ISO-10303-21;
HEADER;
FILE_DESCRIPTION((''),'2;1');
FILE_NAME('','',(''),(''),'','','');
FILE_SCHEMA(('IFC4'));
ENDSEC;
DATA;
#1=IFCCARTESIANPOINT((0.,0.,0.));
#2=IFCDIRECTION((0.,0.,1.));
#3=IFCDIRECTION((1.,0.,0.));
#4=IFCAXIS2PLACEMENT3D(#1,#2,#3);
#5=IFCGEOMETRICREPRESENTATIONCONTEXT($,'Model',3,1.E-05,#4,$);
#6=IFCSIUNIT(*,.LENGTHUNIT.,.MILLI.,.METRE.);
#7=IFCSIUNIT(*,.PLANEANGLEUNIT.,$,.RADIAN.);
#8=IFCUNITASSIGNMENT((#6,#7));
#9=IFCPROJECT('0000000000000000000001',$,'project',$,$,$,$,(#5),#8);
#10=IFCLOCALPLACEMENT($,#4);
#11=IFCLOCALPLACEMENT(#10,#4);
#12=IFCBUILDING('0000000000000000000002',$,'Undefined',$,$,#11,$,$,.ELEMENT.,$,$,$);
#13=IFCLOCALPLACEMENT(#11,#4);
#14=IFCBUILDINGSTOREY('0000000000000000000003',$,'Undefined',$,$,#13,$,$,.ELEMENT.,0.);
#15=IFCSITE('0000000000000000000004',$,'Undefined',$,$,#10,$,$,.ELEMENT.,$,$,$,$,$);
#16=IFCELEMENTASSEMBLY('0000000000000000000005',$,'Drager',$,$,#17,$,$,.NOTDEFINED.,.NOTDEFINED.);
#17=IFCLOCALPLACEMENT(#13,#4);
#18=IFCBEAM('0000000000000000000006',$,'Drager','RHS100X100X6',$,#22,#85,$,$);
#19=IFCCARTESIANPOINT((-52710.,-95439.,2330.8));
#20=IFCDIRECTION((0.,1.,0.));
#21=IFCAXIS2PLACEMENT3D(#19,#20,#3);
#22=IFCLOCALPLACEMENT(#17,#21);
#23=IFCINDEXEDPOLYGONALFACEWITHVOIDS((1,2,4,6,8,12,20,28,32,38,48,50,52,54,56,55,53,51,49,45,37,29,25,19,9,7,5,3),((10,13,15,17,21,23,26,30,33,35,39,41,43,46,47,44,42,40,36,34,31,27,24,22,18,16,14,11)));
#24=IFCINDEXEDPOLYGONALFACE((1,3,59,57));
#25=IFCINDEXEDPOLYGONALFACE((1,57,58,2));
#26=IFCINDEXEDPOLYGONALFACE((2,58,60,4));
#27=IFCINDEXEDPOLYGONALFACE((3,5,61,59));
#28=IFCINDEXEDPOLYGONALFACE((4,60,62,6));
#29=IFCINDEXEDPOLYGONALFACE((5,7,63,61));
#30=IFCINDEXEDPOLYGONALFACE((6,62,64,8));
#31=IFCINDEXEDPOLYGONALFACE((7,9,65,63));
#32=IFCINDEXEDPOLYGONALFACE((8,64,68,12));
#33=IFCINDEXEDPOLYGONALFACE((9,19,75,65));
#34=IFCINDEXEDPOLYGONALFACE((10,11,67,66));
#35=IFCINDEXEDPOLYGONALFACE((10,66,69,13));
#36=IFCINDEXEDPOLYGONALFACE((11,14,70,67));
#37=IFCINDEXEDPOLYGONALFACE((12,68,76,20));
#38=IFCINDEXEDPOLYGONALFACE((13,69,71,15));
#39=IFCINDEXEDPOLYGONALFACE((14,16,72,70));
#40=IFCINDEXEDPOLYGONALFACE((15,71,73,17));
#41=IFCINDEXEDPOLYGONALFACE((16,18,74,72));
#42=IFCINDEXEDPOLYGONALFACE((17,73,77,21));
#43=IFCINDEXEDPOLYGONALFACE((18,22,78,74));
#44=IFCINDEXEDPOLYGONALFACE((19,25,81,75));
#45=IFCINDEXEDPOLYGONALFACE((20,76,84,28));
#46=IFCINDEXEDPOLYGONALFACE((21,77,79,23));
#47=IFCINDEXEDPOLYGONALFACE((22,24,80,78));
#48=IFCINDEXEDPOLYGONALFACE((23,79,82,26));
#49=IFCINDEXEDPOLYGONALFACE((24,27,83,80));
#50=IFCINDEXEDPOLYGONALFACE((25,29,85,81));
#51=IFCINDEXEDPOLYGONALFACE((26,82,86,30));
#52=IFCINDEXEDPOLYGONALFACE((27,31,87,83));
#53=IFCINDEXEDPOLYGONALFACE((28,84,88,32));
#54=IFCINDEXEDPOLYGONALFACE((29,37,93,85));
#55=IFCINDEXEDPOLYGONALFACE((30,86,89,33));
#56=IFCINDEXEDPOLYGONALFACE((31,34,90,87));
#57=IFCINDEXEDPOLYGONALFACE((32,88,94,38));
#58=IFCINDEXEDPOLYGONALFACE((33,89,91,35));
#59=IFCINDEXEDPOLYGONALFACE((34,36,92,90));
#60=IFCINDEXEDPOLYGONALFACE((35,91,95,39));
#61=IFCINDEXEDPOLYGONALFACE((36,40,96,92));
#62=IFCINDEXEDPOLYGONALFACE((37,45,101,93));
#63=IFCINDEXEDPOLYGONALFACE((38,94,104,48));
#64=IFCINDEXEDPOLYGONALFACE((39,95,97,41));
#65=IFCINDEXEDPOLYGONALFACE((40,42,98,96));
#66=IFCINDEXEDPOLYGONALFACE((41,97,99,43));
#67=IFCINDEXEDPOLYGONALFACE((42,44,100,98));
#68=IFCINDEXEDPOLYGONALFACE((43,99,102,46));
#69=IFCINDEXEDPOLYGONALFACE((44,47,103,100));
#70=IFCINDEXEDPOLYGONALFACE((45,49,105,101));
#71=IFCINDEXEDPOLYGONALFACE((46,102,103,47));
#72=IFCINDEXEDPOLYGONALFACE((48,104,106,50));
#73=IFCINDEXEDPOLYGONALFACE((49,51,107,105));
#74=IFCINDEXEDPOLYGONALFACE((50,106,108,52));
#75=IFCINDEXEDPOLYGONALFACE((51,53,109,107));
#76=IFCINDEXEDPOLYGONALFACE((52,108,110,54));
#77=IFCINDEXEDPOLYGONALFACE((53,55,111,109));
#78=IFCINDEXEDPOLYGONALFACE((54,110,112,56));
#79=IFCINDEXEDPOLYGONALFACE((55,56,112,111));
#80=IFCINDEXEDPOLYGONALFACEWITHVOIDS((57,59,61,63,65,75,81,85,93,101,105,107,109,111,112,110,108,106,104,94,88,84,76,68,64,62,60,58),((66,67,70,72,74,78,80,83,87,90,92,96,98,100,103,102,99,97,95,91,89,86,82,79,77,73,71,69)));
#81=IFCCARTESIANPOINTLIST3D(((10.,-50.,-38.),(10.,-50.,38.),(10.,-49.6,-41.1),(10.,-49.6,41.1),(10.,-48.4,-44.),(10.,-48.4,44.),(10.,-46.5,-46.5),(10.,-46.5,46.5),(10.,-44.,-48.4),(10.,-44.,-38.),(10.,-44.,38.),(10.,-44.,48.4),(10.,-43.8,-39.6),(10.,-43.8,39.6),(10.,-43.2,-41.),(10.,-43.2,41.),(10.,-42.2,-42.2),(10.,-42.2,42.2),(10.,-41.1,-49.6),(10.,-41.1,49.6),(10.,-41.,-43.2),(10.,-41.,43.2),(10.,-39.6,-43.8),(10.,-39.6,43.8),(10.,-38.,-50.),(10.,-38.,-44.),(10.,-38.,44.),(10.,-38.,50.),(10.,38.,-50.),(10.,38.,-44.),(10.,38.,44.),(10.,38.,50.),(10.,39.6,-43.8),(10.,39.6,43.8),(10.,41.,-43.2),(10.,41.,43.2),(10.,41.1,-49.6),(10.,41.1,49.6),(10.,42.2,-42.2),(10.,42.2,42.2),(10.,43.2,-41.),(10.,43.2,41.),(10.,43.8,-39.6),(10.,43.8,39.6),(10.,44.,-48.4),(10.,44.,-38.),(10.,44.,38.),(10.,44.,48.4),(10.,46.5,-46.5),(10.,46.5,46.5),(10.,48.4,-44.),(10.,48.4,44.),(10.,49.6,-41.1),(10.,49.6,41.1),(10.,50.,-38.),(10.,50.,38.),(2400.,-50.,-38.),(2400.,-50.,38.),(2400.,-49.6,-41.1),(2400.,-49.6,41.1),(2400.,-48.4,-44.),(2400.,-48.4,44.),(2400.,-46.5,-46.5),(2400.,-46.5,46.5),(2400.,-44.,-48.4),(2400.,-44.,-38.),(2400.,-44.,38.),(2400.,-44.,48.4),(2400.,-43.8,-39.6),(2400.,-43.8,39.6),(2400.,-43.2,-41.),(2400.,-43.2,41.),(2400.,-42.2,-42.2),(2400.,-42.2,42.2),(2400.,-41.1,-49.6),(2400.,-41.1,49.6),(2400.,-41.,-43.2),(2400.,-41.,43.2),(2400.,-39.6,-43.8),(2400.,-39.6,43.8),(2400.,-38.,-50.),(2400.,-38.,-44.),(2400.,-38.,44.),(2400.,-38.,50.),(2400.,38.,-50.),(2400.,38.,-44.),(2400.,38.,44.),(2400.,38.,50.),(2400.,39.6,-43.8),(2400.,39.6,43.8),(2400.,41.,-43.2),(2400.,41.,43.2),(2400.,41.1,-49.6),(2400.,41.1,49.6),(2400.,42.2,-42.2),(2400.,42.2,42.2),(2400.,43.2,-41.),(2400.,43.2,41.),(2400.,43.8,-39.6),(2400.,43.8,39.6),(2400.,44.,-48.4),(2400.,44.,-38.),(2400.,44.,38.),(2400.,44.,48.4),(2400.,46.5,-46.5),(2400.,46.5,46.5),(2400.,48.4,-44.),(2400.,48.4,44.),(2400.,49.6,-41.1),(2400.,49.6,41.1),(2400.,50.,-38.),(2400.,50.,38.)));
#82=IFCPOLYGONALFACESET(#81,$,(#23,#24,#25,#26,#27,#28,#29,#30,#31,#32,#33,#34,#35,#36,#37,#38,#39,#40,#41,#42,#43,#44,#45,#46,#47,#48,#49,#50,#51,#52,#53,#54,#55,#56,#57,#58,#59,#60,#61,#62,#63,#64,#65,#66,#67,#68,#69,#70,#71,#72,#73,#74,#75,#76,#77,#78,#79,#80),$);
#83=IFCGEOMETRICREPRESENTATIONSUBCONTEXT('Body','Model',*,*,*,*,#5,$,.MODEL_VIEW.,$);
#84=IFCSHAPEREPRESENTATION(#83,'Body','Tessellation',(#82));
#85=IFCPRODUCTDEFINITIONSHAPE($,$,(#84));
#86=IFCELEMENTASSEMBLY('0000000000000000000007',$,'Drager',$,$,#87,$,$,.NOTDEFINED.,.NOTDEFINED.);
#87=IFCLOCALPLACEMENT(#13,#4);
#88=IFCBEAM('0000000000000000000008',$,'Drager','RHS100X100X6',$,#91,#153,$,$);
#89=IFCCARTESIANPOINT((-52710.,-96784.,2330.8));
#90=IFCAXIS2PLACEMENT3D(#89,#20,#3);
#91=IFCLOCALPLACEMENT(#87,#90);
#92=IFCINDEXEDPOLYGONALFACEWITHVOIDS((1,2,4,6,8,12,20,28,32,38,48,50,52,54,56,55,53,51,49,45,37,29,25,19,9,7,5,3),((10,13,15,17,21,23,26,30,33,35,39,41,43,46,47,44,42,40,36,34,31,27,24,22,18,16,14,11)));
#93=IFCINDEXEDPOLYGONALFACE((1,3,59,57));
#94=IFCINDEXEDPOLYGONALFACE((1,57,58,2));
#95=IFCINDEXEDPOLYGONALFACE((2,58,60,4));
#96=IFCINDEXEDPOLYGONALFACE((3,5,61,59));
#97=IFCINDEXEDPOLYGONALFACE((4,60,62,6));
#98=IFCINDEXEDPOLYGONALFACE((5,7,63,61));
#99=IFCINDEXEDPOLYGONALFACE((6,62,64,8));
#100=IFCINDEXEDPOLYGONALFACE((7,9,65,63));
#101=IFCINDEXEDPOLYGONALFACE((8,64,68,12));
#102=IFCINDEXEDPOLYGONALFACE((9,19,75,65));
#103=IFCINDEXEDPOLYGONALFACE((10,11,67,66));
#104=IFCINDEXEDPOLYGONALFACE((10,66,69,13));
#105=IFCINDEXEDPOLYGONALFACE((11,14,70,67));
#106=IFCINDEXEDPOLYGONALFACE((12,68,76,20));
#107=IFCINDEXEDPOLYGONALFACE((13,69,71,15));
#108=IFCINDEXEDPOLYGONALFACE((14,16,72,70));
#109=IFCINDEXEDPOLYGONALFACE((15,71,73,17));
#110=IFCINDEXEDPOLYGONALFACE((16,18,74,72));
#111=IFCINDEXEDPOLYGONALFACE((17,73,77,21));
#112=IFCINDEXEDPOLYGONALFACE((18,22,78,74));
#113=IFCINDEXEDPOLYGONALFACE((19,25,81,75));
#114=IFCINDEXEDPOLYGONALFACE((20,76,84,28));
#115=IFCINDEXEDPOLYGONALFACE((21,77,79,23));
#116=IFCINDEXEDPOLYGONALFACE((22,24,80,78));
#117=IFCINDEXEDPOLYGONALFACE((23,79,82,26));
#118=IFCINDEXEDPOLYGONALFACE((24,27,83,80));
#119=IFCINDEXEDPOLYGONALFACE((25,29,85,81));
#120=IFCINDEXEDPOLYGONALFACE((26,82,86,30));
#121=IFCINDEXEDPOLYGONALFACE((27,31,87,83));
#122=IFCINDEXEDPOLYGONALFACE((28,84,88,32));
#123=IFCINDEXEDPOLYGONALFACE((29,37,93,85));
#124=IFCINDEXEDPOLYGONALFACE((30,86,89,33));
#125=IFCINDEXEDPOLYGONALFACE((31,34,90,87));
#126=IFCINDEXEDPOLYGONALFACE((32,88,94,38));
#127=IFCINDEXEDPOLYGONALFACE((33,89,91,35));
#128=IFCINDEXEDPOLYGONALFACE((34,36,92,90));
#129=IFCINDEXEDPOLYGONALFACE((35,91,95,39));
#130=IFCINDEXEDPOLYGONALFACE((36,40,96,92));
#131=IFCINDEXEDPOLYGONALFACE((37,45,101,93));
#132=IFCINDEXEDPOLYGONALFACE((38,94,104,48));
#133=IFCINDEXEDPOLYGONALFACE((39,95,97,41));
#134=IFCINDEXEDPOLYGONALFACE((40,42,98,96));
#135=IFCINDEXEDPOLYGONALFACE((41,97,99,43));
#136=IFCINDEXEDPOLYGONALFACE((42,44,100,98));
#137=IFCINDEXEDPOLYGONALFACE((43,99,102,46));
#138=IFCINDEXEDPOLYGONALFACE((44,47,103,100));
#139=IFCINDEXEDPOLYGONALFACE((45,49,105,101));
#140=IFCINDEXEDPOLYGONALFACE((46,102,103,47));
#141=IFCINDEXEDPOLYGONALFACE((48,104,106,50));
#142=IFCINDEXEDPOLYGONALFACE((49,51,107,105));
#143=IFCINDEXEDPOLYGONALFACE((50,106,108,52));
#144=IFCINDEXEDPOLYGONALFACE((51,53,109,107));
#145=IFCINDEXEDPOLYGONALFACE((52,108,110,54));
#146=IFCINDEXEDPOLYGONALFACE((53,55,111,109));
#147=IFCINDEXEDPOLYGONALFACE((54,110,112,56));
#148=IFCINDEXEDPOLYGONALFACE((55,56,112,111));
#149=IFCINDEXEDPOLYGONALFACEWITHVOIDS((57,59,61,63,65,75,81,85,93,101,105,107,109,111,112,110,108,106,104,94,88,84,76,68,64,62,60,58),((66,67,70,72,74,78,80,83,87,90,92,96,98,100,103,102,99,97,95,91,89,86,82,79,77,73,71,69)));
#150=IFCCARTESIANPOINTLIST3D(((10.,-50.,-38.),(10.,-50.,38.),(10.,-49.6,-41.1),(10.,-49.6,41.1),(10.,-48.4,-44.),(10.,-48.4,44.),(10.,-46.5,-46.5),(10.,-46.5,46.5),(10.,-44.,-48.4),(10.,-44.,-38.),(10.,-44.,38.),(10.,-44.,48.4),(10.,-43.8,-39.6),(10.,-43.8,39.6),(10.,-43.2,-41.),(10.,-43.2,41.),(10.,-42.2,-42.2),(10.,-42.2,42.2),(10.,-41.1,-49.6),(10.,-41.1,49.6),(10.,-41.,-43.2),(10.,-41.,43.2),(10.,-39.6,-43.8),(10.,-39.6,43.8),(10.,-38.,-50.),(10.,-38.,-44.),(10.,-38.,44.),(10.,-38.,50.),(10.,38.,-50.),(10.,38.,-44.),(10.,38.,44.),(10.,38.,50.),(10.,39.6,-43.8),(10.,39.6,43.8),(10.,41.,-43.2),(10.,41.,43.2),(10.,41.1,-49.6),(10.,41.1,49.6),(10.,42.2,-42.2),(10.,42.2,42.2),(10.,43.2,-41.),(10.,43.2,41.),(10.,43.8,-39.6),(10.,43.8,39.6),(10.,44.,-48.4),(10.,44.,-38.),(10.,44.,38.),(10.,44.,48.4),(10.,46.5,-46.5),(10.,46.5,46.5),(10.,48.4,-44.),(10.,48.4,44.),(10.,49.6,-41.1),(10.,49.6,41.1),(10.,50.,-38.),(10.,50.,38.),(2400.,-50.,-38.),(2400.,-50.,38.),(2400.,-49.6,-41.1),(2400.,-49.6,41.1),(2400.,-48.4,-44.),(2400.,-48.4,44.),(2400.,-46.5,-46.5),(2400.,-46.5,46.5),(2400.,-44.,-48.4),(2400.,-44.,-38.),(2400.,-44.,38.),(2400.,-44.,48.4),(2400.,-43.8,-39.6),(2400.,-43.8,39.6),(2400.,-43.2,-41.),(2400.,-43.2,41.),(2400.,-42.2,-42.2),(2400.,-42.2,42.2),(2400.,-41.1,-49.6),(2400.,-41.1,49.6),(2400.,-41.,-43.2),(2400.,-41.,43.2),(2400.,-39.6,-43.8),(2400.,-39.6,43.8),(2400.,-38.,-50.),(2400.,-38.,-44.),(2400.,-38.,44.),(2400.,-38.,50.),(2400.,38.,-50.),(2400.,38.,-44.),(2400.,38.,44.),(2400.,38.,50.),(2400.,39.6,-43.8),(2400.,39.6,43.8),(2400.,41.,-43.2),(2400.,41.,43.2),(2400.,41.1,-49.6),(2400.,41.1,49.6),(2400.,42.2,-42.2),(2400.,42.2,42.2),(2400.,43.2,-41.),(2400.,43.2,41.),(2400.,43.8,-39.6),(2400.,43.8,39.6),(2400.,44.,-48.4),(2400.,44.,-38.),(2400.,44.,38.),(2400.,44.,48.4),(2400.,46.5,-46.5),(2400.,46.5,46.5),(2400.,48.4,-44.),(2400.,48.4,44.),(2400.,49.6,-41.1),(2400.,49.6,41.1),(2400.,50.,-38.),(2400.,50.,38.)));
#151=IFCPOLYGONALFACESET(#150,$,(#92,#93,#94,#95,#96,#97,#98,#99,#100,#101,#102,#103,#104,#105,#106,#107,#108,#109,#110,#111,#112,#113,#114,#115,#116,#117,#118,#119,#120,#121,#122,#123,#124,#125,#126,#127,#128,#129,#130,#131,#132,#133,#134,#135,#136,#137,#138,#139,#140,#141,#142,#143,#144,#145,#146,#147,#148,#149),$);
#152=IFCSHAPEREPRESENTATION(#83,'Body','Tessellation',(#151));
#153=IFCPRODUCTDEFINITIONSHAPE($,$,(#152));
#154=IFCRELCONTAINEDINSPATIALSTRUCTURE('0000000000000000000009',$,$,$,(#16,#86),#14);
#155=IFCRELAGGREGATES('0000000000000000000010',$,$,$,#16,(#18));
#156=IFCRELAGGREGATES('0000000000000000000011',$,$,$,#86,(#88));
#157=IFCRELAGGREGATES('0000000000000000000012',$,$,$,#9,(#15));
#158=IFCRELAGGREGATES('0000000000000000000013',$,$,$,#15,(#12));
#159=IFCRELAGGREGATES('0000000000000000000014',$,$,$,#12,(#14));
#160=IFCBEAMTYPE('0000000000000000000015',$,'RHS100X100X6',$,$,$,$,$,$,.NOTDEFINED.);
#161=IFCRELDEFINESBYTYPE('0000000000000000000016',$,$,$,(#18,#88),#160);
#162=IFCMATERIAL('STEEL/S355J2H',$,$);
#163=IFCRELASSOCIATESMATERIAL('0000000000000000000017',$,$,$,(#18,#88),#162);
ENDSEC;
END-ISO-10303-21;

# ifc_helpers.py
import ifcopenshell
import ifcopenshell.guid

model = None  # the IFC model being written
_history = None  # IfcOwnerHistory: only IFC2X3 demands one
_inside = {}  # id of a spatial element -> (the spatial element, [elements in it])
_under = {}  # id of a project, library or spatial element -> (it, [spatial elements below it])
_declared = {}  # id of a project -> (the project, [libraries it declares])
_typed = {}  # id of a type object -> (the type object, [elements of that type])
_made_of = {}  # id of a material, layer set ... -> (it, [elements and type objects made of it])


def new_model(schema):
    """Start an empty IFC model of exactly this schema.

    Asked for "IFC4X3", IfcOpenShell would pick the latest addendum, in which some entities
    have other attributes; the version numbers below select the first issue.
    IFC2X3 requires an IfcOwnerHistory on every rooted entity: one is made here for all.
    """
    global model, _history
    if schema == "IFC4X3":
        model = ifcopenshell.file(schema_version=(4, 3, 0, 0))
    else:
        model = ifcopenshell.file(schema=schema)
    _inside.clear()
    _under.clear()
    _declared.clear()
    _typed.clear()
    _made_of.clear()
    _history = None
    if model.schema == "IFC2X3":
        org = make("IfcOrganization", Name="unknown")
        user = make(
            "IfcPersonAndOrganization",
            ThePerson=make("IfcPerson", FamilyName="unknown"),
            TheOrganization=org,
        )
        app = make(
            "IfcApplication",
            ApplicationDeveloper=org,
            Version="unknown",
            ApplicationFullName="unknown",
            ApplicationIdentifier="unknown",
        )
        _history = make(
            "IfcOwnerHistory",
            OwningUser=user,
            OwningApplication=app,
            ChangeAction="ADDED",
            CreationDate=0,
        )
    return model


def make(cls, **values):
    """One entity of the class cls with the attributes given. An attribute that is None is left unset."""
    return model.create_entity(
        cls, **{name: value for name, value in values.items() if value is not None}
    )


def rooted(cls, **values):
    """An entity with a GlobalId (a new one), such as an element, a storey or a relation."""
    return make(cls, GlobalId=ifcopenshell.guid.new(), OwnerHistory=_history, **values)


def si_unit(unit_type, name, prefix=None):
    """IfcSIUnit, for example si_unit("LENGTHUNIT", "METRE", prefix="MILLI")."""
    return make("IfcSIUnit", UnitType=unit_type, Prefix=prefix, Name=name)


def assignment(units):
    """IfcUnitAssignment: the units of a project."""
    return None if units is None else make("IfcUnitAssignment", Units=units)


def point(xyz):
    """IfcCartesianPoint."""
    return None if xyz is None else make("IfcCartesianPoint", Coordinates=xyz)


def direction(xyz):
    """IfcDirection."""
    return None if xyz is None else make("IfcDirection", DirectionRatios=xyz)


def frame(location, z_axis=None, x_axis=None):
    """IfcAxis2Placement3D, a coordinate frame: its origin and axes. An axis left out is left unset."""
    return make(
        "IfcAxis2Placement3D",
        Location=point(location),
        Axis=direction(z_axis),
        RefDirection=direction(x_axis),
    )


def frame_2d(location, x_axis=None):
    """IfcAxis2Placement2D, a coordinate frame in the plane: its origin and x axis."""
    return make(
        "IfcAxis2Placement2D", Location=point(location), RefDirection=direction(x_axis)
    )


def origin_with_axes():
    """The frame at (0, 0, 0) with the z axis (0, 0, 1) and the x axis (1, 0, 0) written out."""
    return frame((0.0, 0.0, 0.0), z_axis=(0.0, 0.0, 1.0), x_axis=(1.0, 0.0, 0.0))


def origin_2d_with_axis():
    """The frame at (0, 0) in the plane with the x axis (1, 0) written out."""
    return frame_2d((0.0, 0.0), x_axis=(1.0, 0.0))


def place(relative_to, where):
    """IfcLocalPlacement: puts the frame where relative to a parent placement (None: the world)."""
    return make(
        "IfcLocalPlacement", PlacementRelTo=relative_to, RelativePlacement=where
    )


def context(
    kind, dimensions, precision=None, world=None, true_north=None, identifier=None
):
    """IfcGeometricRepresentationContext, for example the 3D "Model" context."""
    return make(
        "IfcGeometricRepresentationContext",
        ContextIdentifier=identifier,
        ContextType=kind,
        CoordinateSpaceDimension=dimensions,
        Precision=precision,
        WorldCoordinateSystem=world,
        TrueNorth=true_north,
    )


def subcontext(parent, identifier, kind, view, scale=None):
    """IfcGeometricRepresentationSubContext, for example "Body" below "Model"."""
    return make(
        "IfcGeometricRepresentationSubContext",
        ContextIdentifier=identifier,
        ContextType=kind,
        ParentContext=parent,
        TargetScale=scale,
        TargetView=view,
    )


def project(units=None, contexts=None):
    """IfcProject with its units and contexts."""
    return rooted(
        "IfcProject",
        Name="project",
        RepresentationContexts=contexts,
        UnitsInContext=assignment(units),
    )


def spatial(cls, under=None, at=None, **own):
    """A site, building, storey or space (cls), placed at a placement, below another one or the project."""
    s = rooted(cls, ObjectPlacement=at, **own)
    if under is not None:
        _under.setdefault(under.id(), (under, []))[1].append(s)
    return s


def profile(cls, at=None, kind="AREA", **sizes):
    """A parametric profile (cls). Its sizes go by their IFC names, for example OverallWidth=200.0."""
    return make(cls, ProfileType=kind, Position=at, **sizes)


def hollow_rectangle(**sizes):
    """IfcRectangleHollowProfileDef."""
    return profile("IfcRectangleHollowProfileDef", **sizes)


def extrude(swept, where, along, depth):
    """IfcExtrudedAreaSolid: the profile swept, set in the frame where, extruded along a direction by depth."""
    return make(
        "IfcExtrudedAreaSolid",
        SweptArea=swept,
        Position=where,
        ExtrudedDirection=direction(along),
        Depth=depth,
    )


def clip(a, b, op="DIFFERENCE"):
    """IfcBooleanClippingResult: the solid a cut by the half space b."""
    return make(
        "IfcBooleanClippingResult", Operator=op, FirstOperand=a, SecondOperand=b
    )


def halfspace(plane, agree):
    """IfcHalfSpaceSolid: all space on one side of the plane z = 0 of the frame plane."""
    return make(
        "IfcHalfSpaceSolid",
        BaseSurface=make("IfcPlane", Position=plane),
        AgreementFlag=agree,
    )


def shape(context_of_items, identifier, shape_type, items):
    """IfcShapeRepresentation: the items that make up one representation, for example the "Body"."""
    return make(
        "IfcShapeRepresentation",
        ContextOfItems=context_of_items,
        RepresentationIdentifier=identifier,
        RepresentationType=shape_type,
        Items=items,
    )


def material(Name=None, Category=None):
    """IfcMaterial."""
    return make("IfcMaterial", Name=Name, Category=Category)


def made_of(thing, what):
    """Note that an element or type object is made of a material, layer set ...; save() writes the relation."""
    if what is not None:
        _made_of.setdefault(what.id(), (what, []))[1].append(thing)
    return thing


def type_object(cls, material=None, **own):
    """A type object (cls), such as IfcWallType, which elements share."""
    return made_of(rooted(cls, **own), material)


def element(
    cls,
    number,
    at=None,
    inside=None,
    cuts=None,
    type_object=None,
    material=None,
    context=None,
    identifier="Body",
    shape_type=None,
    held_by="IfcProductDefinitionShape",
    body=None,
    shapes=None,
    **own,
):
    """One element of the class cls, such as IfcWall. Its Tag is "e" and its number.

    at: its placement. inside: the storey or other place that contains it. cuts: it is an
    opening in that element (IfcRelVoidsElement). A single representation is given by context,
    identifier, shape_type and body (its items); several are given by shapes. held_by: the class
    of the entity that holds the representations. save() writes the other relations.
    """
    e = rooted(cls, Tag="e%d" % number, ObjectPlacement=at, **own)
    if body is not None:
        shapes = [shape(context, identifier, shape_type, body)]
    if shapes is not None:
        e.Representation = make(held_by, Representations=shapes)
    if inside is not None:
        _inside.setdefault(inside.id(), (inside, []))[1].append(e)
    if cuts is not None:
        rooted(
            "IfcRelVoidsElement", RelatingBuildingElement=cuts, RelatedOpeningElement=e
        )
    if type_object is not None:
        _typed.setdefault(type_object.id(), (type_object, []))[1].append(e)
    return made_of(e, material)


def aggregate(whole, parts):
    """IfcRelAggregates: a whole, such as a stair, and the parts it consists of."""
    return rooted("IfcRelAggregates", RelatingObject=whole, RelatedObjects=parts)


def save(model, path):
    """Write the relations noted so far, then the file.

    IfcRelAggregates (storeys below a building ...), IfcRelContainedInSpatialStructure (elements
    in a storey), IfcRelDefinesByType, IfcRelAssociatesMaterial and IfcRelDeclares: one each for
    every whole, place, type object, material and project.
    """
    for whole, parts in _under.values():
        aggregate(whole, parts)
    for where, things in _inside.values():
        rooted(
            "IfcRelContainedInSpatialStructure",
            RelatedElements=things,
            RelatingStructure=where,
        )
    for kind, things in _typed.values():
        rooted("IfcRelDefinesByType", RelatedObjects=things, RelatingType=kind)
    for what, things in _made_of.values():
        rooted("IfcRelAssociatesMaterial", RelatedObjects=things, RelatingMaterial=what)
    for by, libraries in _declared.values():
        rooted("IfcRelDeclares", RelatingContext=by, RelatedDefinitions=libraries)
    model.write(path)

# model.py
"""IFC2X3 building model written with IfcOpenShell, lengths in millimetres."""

from ifc_helpers import new_model, si_unit, frame, origin_with_axes, origin_2d_with_axis, place, context, subcontext, project, spatial, hollow_rectangle, extrude, clip, halfspace, material, type_object, element, aggregate, save


model = new_model("IFC2X3")

# Units and contexts
model_context = context("Model", 3, precision=1e-05, world=origin_with_axes())
body_context = subcontext(model_context, "Body", "Model", "MODEL_VIEW")
ifc_project = project(units=[si_unit("LENGTHUNIT", "METRE", prefix="MILLI"), si_unit("PLANEANGLEUNIT", "RADIAN")], contexts=[model_context])

# Site, building, storey
site_placement = place(None, origin_with_axes())
site = spatial("IfcSite", under=ifc_project, at=site_placement, Name="Undefined", CompositionType="ELEMENT")
building_placement = place(site_placement, origin_with_axes())
building = spatial("IfcBuilding", under=site, at=building_placement, Name="Undefined", CompositionType="ELEMENT")
storey_placement = place(building_placement, origin_with_axes())
storey = spatial("IfcBuildingStorey", under=building, at=storey_placement, Name="Undefined", CompositionType="ELEMENT", Elevation=0.0)

# Shared definitions
ifc_material_1 = material(Name="STEEL/S355J2H")

# Element assemblies, beams
assembly_1_placement = place(storey_placement, origin_with_axes())
assembly_1 = element("IfcElementAssembly", 1, at=assembly_1_placement, inside=storey, Name="Drager", AssemblyPlace="NOTDEFINED", PredefinedType="NOTDEFINED")
beam_type_1 = type_object("IfcBeamType", Name="RHS100X100X6", PredefinedType="NOTDEFINED")
beam_1_placement = place(assembly_1_placement, frame((-52710.0, -95439.0, 2330.8), z_axis=(0.0, 1.0, 0.0), x_axis=(1.0, 0.0, 0.0)))
beam_1 = element("IfcBeam", 2, at=beam_1_placement, type_object=beam_type_1, material=ifc_material_1, Name="Drager", Description="RHS100X100X6", context=body_context, shape_type="Clipping", body=[
    clip(clip(extrude(hollow_rectangle(XDim=100.0, YDim=100.0, WallThickness=6.0, InnerFilletRadius=6.0, OuterFilletRadius=12.0, at=origin_2d_with_axis()), frame((2410.0, 0.0, 0.0), z_axis=(-1.0, 0.0, 0.0), x_axis=(0.0, -1.0, 0.0)), (0.0, 0.0, 1.0), 2410.0), halfspace(frame((2400.0, 50.0, 0.0), z_axis=(-1.0, 0.0, 0.0), x_axis=(0.0, 0.0, 1.0)), True)), halfspace(frame((10.0, 0.0, -50.0), z_axis=(1.0, 0.0, 0.0), x_axis=(0.0, -1.0, 0.0)), True)),
])
assembly_2_placement = place(storey_placement, origin_with_axes())
assembly_2 = element("IfcElementAssembly", 3, at=assembly_2_placement, inside=storey, Name="Drager", AssemblyPlace="NOTDEFINED", PredefinedType="NOTDEFINED")
beam_2_placement = place(assembly_2_placement, frame((-52710.0, -96784.0, 2330.8), z_axis=(0.0, 1.0, 0.0), x_axis=(1.0, 0.0, 0.0)))
beam_2 = element("IfcBeam", 4, at=beam_2_placement, type_object=beam_type_1, material=ifc_material_1, Name="Drager", Description="RHS100X100X6", context=body_context, shape_type="Clipping", body=[
    clip(clip(extrude(hollow_rectangle(XDim=100.0, YDim=100.0, WallThickness=6.0, InnerFilletRadius=6.0, OuterFilletRadius=12.0, at=origin_2d_with_axis()), frame((2410.0, 0.0, 0.0), z_axis=(-1.0, 0.0, 0.0), x_axis=(0.0, -1.0, 0.0)), (0.0, 0.0, 1.0), 2410.0), halfspace(frame((2400.0, 50.0, 0.0), z_axis=(-1.0, 0.0, 0.0), x_axis=(0.0, 0.0, 1.0)), True)), halfspace(frame((10.0, 0.0, -50.0), z_axis=(1.0, 0.0, 0.0), x_axis=(0.0, -1.0, 0.0)), True)),
])

aggregate(assembly_1, [beam_1])
aggregate(assembly_2, [beam_2])

save(model, "model.ifc")
